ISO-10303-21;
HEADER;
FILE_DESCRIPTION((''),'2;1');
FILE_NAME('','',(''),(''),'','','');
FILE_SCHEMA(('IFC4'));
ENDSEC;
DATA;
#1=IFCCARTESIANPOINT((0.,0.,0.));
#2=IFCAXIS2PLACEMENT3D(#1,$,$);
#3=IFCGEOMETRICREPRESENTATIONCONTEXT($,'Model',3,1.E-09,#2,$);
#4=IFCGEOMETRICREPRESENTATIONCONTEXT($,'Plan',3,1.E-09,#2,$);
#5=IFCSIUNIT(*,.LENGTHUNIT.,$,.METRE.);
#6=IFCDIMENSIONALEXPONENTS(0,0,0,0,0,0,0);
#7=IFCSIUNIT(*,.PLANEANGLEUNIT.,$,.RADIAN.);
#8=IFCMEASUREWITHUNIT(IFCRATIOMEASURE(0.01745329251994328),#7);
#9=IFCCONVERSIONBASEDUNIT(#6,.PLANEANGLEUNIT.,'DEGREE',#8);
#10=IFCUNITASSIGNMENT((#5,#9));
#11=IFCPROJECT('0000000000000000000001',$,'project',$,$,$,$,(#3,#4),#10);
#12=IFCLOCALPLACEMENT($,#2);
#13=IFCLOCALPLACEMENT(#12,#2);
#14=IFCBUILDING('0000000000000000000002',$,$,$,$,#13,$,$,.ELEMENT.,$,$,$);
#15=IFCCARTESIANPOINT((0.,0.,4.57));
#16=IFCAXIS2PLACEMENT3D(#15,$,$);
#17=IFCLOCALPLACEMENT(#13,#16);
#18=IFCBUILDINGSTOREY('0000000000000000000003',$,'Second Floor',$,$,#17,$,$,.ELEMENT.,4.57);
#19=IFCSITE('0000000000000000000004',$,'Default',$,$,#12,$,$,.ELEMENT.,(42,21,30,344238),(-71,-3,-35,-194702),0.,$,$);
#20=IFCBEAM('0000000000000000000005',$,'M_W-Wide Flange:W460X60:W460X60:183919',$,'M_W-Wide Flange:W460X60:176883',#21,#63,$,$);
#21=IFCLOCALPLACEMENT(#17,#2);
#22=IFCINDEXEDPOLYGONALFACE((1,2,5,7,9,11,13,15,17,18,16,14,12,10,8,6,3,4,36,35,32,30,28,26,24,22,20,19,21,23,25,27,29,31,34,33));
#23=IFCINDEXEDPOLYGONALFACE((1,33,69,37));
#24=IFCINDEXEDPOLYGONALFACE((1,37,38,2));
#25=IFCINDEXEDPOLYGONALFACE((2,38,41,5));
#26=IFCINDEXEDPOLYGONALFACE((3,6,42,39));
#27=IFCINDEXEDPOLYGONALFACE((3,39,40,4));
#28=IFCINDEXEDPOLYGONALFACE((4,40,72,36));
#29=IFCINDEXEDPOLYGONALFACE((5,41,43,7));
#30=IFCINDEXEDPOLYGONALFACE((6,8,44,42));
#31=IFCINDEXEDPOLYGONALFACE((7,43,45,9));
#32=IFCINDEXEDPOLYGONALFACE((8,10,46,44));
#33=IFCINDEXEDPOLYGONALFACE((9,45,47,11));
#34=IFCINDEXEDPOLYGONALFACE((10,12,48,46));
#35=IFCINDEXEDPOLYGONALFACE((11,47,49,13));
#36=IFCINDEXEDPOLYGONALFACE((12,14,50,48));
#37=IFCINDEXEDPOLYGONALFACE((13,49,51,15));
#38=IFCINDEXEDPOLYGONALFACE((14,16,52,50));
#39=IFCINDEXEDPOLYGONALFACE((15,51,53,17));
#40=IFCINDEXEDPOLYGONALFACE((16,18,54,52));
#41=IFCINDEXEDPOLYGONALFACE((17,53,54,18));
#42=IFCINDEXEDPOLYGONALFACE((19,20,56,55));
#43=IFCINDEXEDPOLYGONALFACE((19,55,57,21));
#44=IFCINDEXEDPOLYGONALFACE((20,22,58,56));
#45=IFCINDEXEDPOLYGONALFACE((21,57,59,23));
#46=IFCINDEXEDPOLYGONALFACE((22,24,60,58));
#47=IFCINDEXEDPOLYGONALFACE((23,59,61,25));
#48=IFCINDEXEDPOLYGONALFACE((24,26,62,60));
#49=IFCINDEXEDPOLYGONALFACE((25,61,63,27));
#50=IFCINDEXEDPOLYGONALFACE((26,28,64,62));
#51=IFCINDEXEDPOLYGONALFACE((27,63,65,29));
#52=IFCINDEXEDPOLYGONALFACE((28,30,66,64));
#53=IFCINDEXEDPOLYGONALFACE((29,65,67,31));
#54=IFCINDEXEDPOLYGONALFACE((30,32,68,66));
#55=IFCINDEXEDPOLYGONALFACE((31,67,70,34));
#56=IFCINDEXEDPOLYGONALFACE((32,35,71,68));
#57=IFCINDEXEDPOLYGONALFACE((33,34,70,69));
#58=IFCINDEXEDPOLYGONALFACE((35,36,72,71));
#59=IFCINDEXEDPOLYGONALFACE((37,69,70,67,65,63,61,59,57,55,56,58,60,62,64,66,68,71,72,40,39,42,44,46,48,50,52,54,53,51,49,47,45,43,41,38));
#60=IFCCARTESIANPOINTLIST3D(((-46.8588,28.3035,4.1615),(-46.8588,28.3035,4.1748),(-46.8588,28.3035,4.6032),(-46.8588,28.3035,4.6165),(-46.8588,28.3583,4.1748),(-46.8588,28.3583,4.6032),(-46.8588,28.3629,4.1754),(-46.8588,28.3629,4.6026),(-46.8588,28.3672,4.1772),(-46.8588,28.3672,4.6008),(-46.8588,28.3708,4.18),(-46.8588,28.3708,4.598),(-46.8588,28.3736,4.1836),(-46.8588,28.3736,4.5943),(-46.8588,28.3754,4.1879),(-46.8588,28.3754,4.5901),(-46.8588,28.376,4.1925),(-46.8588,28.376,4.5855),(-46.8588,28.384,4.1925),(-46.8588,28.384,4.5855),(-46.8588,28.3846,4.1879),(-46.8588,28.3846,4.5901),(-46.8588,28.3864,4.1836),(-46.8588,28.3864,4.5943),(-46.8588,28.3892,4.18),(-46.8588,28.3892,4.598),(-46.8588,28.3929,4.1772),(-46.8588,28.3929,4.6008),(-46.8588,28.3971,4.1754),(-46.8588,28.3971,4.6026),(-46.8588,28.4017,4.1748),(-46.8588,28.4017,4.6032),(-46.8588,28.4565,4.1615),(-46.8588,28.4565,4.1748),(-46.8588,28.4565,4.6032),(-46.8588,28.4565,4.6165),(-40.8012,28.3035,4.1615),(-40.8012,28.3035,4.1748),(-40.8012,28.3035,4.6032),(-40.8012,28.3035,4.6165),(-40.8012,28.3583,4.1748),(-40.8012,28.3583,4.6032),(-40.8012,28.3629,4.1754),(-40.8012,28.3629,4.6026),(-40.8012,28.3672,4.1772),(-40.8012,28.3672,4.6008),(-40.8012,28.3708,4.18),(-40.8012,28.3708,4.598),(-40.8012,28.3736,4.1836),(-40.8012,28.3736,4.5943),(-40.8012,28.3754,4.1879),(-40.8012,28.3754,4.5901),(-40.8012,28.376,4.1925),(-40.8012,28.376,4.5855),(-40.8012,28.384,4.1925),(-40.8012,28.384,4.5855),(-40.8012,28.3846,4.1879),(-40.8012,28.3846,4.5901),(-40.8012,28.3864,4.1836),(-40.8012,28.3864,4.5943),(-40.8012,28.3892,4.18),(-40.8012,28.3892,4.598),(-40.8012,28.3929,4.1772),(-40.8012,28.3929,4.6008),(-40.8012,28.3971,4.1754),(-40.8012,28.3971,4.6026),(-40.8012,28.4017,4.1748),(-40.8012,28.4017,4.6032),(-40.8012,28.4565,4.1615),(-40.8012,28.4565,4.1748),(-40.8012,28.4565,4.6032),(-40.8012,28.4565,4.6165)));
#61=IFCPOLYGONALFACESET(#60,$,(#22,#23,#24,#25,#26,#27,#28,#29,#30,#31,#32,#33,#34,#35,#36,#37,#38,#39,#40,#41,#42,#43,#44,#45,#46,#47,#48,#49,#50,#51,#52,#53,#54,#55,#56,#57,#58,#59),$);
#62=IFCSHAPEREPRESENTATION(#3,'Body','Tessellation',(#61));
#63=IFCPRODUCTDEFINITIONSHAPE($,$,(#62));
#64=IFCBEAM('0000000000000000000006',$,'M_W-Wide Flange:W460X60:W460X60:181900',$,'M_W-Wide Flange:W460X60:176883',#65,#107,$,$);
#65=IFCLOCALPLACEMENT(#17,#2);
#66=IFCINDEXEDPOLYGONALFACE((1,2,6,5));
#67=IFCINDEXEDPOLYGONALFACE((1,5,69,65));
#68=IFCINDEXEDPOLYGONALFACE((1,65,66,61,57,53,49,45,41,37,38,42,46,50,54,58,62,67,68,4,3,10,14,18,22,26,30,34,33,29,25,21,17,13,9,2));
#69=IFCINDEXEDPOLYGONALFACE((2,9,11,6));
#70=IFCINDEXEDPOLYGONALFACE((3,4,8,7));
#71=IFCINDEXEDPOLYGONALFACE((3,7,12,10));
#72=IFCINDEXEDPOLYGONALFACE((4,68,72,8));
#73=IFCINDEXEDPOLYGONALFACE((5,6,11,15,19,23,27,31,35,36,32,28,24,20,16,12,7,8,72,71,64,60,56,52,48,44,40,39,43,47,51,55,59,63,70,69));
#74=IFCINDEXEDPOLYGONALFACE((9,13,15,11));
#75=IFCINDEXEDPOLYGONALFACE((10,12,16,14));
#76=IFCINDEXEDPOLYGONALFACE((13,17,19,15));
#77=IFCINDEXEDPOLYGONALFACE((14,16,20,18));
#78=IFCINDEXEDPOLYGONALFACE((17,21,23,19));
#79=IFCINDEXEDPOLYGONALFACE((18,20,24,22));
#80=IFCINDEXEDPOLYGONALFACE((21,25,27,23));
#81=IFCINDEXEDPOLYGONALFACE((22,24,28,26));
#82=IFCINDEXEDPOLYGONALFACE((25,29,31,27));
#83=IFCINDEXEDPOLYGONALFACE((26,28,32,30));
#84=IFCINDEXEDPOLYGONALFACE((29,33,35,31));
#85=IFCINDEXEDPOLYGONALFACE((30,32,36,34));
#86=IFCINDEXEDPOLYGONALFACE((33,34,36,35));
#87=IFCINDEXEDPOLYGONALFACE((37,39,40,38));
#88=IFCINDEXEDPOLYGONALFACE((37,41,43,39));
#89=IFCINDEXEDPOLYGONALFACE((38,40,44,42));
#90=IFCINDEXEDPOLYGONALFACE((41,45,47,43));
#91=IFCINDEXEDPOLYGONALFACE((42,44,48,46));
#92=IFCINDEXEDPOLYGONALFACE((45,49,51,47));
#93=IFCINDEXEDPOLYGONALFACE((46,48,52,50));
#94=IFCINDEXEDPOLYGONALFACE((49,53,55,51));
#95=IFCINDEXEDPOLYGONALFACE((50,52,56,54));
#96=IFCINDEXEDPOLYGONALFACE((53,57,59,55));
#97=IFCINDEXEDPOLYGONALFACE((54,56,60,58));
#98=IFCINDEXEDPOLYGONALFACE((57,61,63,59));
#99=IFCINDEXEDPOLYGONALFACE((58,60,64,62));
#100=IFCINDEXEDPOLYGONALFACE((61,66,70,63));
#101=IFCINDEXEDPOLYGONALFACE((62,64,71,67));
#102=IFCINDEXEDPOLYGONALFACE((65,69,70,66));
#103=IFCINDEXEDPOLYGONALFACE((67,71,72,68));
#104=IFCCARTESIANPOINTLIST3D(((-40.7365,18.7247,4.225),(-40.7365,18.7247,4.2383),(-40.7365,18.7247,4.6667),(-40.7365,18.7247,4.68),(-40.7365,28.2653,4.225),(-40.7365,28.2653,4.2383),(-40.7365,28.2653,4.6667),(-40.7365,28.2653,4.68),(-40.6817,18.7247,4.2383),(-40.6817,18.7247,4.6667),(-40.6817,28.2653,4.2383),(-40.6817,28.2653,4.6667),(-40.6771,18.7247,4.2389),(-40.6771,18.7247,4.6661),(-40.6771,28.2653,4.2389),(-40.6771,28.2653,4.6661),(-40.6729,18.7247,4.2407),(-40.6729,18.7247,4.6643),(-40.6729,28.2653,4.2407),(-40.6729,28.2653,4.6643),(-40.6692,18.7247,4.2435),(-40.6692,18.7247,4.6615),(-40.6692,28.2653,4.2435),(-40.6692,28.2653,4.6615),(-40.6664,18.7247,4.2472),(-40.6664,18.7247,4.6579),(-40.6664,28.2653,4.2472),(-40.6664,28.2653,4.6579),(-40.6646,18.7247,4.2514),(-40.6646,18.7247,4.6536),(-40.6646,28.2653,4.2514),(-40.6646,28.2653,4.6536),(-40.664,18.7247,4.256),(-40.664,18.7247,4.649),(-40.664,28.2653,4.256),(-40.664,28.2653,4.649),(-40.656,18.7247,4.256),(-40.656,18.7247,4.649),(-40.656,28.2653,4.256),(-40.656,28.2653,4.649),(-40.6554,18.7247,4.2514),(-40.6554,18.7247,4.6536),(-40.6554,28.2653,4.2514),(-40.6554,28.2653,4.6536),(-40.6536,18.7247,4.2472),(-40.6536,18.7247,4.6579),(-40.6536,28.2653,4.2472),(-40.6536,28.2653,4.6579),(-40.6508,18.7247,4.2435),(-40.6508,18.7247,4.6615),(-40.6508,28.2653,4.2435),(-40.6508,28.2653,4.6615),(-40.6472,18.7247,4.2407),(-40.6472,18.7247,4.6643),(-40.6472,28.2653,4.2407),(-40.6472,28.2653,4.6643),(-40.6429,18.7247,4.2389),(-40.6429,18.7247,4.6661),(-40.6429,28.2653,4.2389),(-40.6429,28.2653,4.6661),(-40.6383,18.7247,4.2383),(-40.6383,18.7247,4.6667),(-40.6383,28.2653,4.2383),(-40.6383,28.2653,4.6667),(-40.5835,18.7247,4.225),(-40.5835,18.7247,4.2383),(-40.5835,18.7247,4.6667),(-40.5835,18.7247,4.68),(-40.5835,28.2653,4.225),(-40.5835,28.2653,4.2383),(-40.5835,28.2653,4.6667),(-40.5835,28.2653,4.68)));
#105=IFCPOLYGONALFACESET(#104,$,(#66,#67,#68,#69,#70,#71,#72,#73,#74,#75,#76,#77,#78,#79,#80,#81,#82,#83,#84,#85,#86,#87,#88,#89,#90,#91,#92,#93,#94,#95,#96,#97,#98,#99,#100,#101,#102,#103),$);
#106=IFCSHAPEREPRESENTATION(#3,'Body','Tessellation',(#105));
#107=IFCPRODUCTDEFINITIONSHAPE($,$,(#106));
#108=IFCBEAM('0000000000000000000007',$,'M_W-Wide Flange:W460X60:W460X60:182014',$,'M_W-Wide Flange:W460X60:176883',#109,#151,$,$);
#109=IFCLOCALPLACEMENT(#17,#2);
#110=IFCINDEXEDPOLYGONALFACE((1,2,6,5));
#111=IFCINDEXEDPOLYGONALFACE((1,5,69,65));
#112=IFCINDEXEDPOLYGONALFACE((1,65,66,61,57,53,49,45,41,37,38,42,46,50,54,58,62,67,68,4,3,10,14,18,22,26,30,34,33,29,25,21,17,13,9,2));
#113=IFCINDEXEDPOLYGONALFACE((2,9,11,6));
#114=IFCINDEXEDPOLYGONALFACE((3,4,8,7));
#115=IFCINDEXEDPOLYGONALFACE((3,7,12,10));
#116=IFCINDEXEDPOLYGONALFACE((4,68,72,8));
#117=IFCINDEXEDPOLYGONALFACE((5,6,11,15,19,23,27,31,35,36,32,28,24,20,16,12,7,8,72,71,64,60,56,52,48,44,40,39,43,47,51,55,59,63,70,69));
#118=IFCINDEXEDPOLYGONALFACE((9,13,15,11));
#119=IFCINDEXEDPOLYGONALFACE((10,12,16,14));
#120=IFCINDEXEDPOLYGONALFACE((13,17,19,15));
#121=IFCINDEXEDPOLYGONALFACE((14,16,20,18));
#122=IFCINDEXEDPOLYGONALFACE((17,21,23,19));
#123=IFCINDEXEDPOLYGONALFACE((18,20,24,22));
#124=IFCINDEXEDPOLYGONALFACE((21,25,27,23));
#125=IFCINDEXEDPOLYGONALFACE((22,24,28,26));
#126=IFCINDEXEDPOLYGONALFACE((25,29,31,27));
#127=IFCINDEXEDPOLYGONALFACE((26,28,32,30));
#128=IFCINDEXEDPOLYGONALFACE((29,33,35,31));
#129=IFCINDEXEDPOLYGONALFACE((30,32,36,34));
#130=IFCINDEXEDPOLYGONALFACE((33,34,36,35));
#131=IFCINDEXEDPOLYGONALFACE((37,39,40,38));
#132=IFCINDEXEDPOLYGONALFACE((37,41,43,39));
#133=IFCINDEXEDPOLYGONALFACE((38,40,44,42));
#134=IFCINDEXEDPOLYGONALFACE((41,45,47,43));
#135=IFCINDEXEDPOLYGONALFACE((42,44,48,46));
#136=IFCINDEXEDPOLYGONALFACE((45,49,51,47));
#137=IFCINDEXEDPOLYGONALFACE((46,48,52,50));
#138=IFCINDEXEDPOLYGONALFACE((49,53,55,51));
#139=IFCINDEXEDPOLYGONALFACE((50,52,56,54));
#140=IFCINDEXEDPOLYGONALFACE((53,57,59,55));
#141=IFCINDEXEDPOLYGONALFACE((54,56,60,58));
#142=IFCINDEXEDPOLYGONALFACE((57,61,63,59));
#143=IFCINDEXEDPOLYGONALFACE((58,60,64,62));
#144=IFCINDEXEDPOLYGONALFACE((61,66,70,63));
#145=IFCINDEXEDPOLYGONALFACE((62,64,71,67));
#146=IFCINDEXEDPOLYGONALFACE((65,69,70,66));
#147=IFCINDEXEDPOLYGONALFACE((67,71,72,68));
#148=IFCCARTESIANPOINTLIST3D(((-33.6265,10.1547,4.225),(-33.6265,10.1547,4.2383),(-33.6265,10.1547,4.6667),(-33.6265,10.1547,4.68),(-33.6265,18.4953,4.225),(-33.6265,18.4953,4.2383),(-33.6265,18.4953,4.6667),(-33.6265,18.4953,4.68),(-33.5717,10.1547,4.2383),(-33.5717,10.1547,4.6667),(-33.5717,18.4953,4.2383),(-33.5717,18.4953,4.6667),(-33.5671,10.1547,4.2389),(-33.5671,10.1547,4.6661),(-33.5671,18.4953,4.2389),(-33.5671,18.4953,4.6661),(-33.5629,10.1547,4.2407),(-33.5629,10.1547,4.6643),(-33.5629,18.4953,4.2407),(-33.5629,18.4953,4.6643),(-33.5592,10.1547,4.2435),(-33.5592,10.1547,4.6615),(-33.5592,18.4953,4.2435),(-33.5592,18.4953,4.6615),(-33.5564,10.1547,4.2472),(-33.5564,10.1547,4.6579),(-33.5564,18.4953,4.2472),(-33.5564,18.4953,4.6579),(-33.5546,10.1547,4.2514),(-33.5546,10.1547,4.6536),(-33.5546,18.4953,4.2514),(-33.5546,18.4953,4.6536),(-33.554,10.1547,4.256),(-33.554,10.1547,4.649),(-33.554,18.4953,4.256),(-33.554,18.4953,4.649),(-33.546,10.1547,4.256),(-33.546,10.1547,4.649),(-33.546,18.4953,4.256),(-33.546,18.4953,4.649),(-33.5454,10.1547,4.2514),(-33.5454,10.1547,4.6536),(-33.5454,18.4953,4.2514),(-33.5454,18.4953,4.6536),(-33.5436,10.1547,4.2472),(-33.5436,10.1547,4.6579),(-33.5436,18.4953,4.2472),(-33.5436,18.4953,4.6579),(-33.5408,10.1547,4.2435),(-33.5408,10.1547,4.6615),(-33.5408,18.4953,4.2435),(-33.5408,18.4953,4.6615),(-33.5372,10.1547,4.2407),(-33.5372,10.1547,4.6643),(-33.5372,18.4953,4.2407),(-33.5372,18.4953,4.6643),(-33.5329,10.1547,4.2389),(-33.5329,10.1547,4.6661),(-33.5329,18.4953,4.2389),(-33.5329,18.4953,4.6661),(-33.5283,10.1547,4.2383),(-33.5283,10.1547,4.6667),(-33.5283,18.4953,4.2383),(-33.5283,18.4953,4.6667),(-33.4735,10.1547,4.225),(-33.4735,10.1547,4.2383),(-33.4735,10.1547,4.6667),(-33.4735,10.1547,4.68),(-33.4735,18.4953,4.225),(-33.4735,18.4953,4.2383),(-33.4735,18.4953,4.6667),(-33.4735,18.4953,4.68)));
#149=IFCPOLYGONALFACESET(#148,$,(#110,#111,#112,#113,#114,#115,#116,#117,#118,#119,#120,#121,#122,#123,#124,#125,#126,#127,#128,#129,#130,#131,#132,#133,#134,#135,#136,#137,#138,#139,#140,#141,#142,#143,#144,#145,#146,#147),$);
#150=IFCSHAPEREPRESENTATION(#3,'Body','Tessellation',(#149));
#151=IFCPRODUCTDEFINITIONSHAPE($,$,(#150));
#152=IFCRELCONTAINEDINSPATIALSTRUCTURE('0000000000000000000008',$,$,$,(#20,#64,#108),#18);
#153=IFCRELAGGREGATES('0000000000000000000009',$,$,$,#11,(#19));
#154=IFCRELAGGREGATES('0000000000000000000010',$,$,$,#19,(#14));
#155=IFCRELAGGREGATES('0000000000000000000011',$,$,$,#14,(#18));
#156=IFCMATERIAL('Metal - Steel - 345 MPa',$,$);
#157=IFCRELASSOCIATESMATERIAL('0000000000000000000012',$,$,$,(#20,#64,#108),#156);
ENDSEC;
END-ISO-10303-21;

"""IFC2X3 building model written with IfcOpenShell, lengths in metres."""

from ifc_helpers import new_model, entity, si_unit, converted_unit, frame, frame_2d, origin, place, context, project, spatial, polyline, circle_curve, parameter, trimmed, segment, composite_curve, outline, extrude, material, element, save


model = new_model("IFC2X3")

# Units and contexts
model_context = context("Model", 3, precision=1e-09, world=origin())
plan_context = context("Plan", 3, precision=1e-09, world=origin())
ifc_project = project(units=[si_unit("LENGTHUNIT", "METRE"), converted_unit("PLANEANGLEUNIT", "DEGREE", entity("IfcRatioMeasure", 0.01745329251994328), si_unit("PLANEANGLEUNIT", "RADIAN"), dimensions=[0, 0, 0, 0, 0, 0, 0])], contexts=[model_context, plan_context])

# Site, building, storey
site_placement = place(None, origin())
site = spatial("IfcSite", under=ifc_project, at=site_placement, Name="Default", CompositionType="ELEMENT", RefLatitude=(42, 21, 30, 344238), RefLongitude=(-71, -3, -35, -194702), RefElevation=0.0)
building_placement = place(site_placement, origin())
building = spatial("IfcBuilding", under=site, at=building_placement, CompositionType="ELEMENT")
storey_placement = place(building_placement, frame((0.0, 0.0, 4.57)))
storey = spatial("IfcBuildingStorey", under=building, at=storey_placement, Name="Second Floor", CompositionType="ELEMENT", Elevation=4.57)

# Shared definitions
ifc_material_1 = material(Name="Metal - Steel - 345 MPa")

# Beams
beam_1_placement = place(storey_placement, frame((-46.997, 28.38, 4.6165), z_axis=(0.0, 0.0, 1.0), x_axis=(0.0, -1.0, 0.0)))
element("IfcBeam", 1, at=beam_1_placement, inside=storey, material=ifc_material_1, Name="M_W-Wide Flange:W460X60:W460X60:183919", ObjectType="M_W-Wide Flange:W460X60:176883", context=model_context, shape_type="SweptSolid", body=[
    extrude(outline(composite_curve([segment(polyline([(-0.0765, -0.2142), (-0.0765, -0.2275)]), True, "CONTINUOUS"), segment(polyline([(-0.0765, -0.2275), (0.0765, -0.2275)]), True, "CONTINUOUS"), segment(polyline([(0.0765, -0.2275), (0.0765, -0.2142)]), True, "CONTINUOUS"), segment(polyline([(0.0765, -0.2142), (0.0217, -0.2142)]), True, "CONTINUOUS"), segment(trimmed(circle_curve(frame_2d((0.0217, -0.1965), x_axis=(1.0, 0.0)), 0.0177), [parameter(180.0)], [parameter(270.0)], True, "PARAMETER"), False, "CONTINUOUS"), segment(polyline([(0.004, -0.1965), (0.004, 0.1965)]), True, "CONTINUOUS"), segment(trimmed(circle_curve(frame_2d((0.0217, 0.1965), x_axis=(1.0, 0.0)), 0.0177), [parameter(90.0)], [parameter(180.0)], True, "PARAMETER"), False, "CONTINUOUS"), segment(polyline([(0.0217, 0.2142), (0.0765, 0.2142)]), True, "CONTINUOUS"), segment(polyline([(0.0765, 0.2142), (0.0765, 0.2275)]), True, "CONTINUOUS"), segment(polyline([(0.0765, 0.2275), (-0.0765, 0.2275)]), True, "CONTINUOUS"), segment(polyline([(-0.0765, 0.2275), (-0.0765, 0.2142)]), True, "CONTINUOUS"), segment(polyline([(-0.0765, 0.2142), (-0.0217, 0.2142)]), True, "CONTINUOUS"), segment(trimmed(circle_curve(frame_2d((-0.0217, 0.1965), x_axis=(1.0, 0.0)), 0.0177), [parameter(360.0)], [parameter(90.0)], True, "PARAMETER"), False, "CONTINUOUS"), segment(polyline([(-0.004, 0.1965), (-0.004, -0.1965)]), True, "CONTINUOUS"), segment(trimmed(circle_curve(frame_2d((-0.0217, -0.1965), x_axis=(1.0, 0.0)), 0.0177), [parameter(270.0)], [parameter(0.0)], True, "PARAMETER"), False, "CONTINUOUS"), segment(polyline([(-0.0217, -0.2142), (-0.0765, -0.2142)]), True, "CONTINUOUS")], self_intersect=False)), frame((0.0, 0.1382, -0.2275), z_axis=(0.0, -1.0, 0.0), x_axis=(1.0, 0.0, 0.0)), (0.0, 0.0, -1.0), 6.0576),
])
beam_2_placement = place(storey_placement, frame((-40.66, 18.6119, 4.68)))
element("IfcBeam", 2, at=beam_2_placement, inside=storey, material=ifc_material_1, Name="M_W-Wide Flange:W460X60:W460X60:181900", ObjectType="M_W-Wide Flange:W460X60:176883", context=model_context, shape_type="SweptSolid", body=[
    extrude(outline(composite_curve([segment(polyline([(-0.0765, -0.2142), (-0.0765, -0.2275)]), True, "CONTINUOUS"), segment(polyline([(-0.0765, -0.2275), (0.0765, -0.2275)]), True, "CONTINUOUS"), segment(polyline([(0.0765, -0.2275), (0.0765, -0.2142)]), True, "CONTINUOUS"), segment(polyline([(0.0765, -0.2142), (0.0217, -0.2142)]), True, "CONTINUOUS"), segment(trimmed(circle_curve(frame_2d((0.0217, -0.1965), x_axis=(0.0, -1.0)), 0.0177), [parameter(270.0)], [parameter(360.0)], True, "PARAMETER"), False, "CONTINUOUS"), segment(polyline([(0.004, -0.1965), (0.004, 0.1965)]), True, "CONTINUOUS"), segment(trimmed(circle_curve(frame_2d((0.0217, 0.1965), x_axis=(-1.0, 0.0)), 0.0177), [parameter(270.0)], [parameter(360.0)], True, "PARAMETER"), False, "CONTINUOUS"), segment(polyline([(0.0217, 0.2142), (0.0765, 0.2142)]), True, "CONTINUOUS"), segment(polyline([(0.0765, 0.2142), (0.0765, 0.2275)]), True, "CONTINUOUS"), segment(polyline([(0.0765, 0.2275), (-0.0765, 0.2275)]), True, "CONTINUOUS"), segment(polyline([(-0.0765, 0.2275), (-0.0765, 0.2142)]), True, "CONTINUOUS"), segment(polyline([(-0.0765, 0.2142), (-0.0217, 0.2142)]), True, "CONTINUOUS"), segment(trimmed(circle_curve(frame_2d((-0.0217, 0.1965), x_axis=(0.0, 1.0)), 0.0177), [parameter(270.0)], [parameter(360.0)], True, "PARAMETER"), False, "CONTINUOUS"), segment(polyline([(-0.004, 0.1965), (-0.004, -0.1965)]), True, "CONTINUOUS"), segment(trimmed(circle_curve(frame_2d((-0.0217, -0.1965), x_axis=(1.0, 0.0)), 0.0177), [parameter(270.0)], [parameter(0.0)], True, "PARAMETER"), False, "CONTINUOUS"), segment(polyline([(-0.0217, -0.2142), (-0.0765, -0.2142)]), True, "CONTINUOUS")], self_intersect=False)), frame((0.0, 0.1128, -0.2275), z_axis=(0.0, -1.0, 0.0), x_axis=(1.0, 0.0, 0.0)), (0.0, 0.0, -1.0), 9.5406),
])
beam_3_placement = place(storey_placement, frame((-33.55, 18.6078, 4.68), z_axis=(0.0, 0.0, 1.0), x_axis=(-1.0, 0.0, 0.0)))
element("IfcBeam", 3, at=beam_3_placement, inside=storey, material=ifc_material_1, Name="M_W-Wide Flange:W460X60:W460X60:182014", ObjectType="M_W-Wide Flange:W460X60:176883", context=model_context, shape_type="SweptSolid", body=[
    extrude(outline(composite_curve([segment(polyline([(0.2142, -0.0765), (0.2275, -0.0765)]), True, "CONTINUOUS"), segment(polyline([(0.2275, -0.0765), (0.2275, 0.0765)]), True, "CONTINUOUS"), segment(polyline([(0.2275, 0.0765), (0.2142, 0.0765)]), True, "CONTINUOUS"), segment(polyline([(0.2142, 0.0765), (0.2142, 0.0217)]), True, "CONTINUOUS"), segment(trimmed(circle_curve(frame_2d((0.1965, 0.0217), x_axis=(1.0, 0.0)), 0.0177), [parameter(270.0)], [parameter(360.0)], True, "PARAMETER"), False, "CONTINUOUS"), segment(polyline([(0.1965, 0.004), (-0.1965, 0.004)]), True, "CONTINUOUS"), segment(trimmed(circle_curve(frame_2d((-0.1965, 0.0217), x_axis=(0.0, -1.0)), 0.0177), [parameter(270.0)], [parameter(360.0)], True, "PARAMETER"), False, "CONTINUOUS"), segment(polyline([(-0.2142, 0.0217), (-0.2142, 0.0765)]), True, "CONTINUOUS"), segment(polyline([(-0.2142, 0.0765), (-0.2275, 0.0765)]), True, "CONTINUOUS"), segment(polyline([(-0.2275, 0.0765), (-0.2275, -0.0765)]), True, "CONTINUOUS"), segment(polyline([(-0.2275, -0.0765), (-0.2142, -0.0765)]), True, "CONTINUOUS"), segment(polyline([(-0.2142, -0.0765), (-0.2142, -0.0217)]), True, "CONTINUOUS"), segment(trimmed(circle_curve(frame_2d((-0.1965, -0.0217), x_axis=(-1.0, 0.0)), 0.0177), [parameter(270.0)], [parameter(360.0)], True, "PARAMETER"), False, "CONTINUOUS"), segment(polyline([(-0.1965, -0.004), (0.1965, -0.004)]), True, "CONTINUOUS"), segment(trimmed(circle_curve(frame_2d((0.1965, -0.0217), x_axis=(0.0, 1.0)), 0.0177), [parameter(270.0)], [parameter(0.0)], True, "PARAMETER"), False, "CONTINUOUS"), segment(polyline([(0.2142, -0.0217), (0.2142, -0.0765)]), True, "CONTINUOUS")], self_intersect=False)), frame((0.0, 8.4531, -0.2275), z_axis=(0.0, -1.0, 0.0), x_axis=(0.0, 0.0, -1.0)), (0.0, 0.0, 1.0), 8.3406),
])

save(model, "model.ifc")
